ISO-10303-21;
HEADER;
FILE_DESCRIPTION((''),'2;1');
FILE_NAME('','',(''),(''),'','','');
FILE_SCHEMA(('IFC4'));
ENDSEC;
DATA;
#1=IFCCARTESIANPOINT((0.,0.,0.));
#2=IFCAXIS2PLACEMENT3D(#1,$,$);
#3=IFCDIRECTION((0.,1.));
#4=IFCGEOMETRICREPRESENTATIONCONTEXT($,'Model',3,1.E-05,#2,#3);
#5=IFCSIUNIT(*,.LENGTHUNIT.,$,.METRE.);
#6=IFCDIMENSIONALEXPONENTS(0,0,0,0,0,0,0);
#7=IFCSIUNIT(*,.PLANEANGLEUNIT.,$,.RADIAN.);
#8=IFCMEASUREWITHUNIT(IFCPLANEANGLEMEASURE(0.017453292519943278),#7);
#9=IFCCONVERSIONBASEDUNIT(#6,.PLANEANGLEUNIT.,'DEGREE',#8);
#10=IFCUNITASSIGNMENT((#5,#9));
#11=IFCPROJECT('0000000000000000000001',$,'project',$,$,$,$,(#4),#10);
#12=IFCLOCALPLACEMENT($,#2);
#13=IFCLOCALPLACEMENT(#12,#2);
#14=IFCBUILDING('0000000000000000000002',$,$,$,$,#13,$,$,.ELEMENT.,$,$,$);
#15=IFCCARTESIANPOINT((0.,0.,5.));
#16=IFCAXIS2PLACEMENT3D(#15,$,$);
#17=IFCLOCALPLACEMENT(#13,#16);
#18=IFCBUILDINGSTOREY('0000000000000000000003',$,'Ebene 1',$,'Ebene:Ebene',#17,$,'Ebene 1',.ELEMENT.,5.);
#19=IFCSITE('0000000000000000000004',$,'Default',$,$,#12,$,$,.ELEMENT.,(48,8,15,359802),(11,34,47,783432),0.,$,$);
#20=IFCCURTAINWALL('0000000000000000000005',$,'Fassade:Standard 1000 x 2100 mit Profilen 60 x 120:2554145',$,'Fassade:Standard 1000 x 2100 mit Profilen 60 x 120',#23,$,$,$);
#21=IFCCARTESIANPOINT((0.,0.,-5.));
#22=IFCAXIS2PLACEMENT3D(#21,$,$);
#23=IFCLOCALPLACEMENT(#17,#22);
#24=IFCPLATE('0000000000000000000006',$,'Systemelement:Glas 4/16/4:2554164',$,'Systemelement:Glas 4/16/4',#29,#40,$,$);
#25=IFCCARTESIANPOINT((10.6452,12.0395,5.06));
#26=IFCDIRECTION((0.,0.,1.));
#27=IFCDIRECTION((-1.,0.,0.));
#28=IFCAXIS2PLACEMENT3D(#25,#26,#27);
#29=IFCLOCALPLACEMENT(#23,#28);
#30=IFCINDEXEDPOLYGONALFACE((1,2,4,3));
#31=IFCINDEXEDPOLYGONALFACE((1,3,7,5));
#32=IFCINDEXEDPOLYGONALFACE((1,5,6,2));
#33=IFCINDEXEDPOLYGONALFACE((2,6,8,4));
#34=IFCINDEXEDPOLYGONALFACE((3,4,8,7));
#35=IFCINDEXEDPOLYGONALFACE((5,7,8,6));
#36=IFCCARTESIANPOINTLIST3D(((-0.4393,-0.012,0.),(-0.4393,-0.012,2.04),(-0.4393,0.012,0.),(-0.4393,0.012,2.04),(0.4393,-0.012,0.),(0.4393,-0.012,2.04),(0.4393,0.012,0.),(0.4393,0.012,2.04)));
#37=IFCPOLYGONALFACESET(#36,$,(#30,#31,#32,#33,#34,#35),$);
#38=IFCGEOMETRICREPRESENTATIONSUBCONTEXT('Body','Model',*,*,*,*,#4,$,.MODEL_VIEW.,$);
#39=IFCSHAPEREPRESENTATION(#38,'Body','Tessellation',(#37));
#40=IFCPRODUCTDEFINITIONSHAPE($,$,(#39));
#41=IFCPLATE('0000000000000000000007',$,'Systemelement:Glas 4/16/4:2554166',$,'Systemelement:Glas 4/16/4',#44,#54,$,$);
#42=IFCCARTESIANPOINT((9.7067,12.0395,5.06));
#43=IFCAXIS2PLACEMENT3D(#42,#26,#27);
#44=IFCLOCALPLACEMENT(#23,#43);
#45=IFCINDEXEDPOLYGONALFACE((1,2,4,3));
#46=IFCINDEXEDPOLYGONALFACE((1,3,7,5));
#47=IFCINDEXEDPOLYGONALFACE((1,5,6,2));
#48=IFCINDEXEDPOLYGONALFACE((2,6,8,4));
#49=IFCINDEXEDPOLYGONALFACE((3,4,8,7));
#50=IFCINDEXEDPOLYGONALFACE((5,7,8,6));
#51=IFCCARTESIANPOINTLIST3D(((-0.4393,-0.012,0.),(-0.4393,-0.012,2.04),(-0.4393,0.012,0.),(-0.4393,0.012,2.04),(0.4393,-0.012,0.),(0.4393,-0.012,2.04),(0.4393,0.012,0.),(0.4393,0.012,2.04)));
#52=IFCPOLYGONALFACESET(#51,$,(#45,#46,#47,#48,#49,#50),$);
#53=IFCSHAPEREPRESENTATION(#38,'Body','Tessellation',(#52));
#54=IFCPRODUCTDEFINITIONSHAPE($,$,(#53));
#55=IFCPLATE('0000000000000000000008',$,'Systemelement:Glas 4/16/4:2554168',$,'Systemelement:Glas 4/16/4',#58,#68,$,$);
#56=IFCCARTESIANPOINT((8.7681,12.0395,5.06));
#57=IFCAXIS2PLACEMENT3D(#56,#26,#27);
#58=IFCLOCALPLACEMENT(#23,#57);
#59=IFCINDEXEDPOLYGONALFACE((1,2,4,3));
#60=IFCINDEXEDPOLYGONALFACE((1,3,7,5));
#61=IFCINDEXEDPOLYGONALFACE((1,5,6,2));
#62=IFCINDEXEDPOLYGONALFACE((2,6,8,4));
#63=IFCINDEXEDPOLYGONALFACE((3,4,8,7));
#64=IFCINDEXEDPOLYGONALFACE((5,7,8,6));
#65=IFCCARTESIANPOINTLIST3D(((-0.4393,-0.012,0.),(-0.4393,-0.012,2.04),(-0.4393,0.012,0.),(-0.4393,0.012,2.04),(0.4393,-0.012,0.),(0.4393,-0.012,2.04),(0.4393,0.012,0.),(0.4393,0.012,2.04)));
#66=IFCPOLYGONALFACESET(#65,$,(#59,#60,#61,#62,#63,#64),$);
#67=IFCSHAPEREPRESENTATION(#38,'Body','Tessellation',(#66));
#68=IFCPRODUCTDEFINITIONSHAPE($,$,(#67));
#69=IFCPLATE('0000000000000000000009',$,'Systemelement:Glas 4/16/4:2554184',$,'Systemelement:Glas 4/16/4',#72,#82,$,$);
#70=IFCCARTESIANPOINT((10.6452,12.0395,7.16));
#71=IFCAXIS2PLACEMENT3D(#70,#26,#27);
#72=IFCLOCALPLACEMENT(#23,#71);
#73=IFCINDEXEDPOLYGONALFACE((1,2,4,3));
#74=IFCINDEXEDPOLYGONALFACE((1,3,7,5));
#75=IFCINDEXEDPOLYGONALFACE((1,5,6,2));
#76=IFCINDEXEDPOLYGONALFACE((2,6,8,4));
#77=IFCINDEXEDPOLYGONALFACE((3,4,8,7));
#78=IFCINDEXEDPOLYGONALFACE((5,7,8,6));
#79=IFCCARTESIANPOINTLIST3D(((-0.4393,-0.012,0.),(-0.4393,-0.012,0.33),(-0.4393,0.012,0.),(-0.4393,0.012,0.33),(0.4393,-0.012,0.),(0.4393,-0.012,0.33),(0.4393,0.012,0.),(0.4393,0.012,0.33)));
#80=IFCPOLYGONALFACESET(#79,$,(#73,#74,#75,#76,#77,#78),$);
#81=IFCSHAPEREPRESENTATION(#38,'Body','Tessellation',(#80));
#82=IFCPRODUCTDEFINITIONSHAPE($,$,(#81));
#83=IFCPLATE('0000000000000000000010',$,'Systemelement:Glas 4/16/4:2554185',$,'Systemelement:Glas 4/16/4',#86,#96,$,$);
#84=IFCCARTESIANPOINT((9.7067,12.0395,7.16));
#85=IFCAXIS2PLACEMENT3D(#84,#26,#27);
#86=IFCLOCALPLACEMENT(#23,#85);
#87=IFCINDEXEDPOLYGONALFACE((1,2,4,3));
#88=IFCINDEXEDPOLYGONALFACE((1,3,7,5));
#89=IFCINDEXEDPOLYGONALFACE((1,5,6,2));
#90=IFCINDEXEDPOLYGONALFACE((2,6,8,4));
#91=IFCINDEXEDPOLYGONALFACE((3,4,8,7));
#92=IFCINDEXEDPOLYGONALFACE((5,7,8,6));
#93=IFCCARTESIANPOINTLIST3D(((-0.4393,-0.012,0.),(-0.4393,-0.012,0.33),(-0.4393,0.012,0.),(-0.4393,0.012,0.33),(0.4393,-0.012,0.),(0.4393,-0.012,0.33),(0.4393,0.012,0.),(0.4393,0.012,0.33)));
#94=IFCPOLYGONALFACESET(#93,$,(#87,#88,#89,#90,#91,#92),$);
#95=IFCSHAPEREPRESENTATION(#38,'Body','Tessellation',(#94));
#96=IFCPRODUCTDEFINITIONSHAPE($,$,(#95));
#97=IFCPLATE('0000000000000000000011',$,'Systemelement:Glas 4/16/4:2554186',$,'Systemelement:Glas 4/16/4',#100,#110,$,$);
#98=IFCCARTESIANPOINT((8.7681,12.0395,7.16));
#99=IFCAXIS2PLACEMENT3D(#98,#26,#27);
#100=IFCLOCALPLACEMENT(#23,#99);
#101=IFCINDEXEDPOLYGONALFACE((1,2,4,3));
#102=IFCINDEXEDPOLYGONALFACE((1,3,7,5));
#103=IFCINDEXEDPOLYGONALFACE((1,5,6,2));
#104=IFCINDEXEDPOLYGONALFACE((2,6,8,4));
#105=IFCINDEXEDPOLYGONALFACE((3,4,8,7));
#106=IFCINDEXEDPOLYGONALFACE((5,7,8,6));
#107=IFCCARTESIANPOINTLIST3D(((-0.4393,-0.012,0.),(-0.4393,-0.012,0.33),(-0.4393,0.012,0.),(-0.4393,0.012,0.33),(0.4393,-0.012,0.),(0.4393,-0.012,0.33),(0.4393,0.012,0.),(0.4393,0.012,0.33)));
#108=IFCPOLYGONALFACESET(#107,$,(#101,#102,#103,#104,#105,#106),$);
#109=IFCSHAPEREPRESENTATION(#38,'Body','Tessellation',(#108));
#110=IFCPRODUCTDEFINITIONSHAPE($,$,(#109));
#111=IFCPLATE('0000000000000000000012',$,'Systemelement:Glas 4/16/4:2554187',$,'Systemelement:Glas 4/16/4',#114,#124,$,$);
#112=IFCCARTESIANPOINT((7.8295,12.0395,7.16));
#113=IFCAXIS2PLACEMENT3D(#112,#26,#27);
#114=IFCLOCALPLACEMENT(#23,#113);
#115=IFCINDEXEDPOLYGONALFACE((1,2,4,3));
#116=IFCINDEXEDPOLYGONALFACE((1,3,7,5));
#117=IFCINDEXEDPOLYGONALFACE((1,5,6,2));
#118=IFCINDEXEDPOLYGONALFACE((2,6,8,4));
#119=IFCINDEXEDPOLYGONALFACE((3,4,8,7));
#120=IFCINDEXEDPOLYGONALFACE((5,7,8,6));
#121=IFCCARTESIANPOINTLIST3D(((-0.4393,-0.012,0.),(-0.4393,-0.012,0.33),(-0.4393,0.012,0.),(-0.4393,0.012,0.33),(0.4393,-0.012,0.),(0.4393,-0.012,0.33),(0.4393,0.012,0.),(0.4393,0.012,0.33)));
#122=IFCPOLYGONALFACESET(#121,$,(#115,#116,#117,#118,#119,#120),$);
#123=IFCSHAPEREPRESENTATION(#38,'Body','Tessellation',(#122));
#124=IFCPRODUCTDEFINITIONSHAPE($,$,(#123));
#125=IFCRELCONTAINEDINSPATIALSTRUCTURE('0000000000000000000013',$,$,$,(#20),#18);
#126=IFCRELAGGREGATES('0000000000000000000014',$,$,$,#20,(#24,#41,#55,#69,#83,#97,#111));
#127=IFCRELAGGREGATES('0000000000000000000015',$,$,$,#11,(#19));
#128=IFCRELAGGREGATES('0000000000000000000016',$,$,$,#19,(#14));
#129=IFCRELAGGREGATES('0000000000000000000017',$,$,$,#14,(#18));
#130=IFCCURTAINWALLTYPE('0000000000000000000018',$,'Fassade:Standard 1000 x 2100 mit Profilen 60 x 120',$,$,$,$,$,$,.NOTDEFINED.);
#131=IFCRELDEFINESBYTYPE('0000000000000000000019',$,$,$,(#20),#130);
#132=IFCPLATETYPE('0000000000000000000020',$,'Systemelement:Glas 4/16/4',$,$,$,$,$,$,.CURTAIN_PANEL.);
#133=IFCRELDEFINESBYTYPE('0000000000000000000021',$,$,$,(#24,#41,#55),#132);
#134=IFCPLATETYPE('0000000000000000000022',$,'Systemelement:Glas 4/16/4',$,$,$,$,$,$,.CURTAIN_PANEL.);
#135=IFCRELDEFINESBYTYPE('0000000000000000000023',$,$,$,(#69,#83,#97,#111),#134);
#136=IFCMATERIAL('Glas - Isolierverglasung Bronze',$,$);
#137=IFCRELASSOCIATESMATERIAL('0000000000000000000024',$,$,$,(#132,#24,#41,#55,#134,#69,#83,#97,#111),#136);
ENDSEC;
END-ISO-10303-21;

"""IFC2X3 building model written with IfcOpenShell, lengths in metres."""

from ifc_helpers import new_model, entity, si_unit, converted_unit, direction, frame, origin, origin_2d_with_axis, place, context, subcontext, project, spatial, rectangle, extrude, source, transform, mapped, material, type_object, type_shapes, element, aggregate, save


model = new_model("IFC2X3")

# Units and contexts
model_context = context("Model", 3, precision=1e-05, world=origin(), true_north=direction((0.0, 1.0)))
body_context = subcontext(model_context, "Body", "Model", "MODEL_VIEW")
ifc_project = project(units=[si_unit("LENGTHUNIT", "METRE"), converted_unit("PLANEANGLEUNIT", "DEGREE", entity("IfcPlaneAngleMeasure", 0.017453292519943278), si_unit("PLANEANGLEUNIT", "RADIAN"), dimensions=[0, 0, 0, 0, 0, 0, 0])], contexts=[model_context])

# Site, building, storey
site_placement = place(None, origin())
site = spatial("IfcSite", under=ifc_project, at=site_placement, Name="Default", CompositionType="ELEMENT", RefLatitude=(48, 8, 15, 359802), RefLongitude=(11, 34, 47, 783432), RefElevation=0.0)
building_placement = place(site_placement, origin())
building = spatial("IfcBuilding", under=site, at=building_placement, CompositionType="ELEMENT")
storey_placement = place(building_placement, frame((0.0, 0.0, 5.0)))
storey = spatial("IfcBuildingStorey", under=building, at=storey_placement, Name="Ebene 1", ObjectType="Ebene:Ebene", LongName="Ebene 1", CompositionType="ELEMENT", Elevation=5.0)

# Curtain wall
curtain_wall_type = type_object("IfcCurtainWallType", Name="Fassade:Standard 1000 x 2100 mit Profilen 60 x 120", PredefinedType="NOTDEFINED")
curtain_wall_placement = place(storey_placement, frame((0.0, 0.0, -5.0)))
curtain_wall = element("IfcCurtainWall", 1, at=curtain_wall_placement, inside=storey, type_object=curtain_wall_type, Name="Fassade:Standard 1000 x 2100 mit Profilen 60 x 120:2554145", ObjectType="Fassade:Standard 1000 x 2100 mit Profilen 60 x 120")

# Plates
ifc_material_1 = material(Name="Glas - Isolierverglasung Bronze")
plate_type_1 = type_object("IfcPlateType", Name="Systemelement:Glas 4/16/4", PredefinedType="CURTAIN_PANEL", material=ifc_material_1)
shared_shape_1 = source(origin(), body_context, "Body", "SweptSolid", [
    extrude(rectangle(XDim=0.024, YDim=0.8786, at=origin_2d_with_axis()), frame((0.0, 0.0, 0.0), z_axis=(0.0, 0.0, 1.0), x_axis=(0.0, 1.0, 0.0)), (0.0, 0.0, 1.0), 2.04),
])
type_shapes(plate_type_1, [shared_shape_1])
plate_1_placement = place(curtain_wall_placement, frame((10.6452, 12.0395, 5.06), z_axis=(0.0, 0.0, 1.0), x_axis=(-1.0, 0.0, 0.0)))
plate_1 = element("IfcPlate", 2, at=plate_1_placement, type_object=plate_type_1, material=ifc_material_1, Name="Systemelement:Glas 4/16/4:2554164", ObjectType="Systemelement:Glas 4/16/4", context=body_context, shape_type="MappedRepresentation", body=[
    mapped(shared_shape_1, transform((0.0, 0.0, 0.0), scale=1.0)),
])
plate_2_placement = place(curtain_wall_placement, frame((9.7067, 12.0395, 5.06), z_axis=(0.0, 0.0, 1.0), x_axis=(-1.0, 0.0, 0.0)))
plate_2 = element("IfcPlate", 3, at=plate_2_placement, type_object=plate_type_1, material=ifc_material_1, Name="Systemelement:Glas 4/16/4:2554166", ObjectType="Systemelement:Glas 4/16/4", context=body_context, shape_type="MappedRepresentation", body=[
    mapped(shared_shape_1, transform((0.0, 0.0, 0.0), scale=1.0)),
])
plate_3_placement = place(curtain_wall_placement, frame((8.7681, 12.0395, 5.06), z_axis=(0.0, 0.0, 1.0), x_axis=(-1.0, 0.0, 0.0)))
plate_3 = element("IfcPlate", 4, at=plate_3_placement, type_object=plate_type_1, material=ifc_material_1, Name="Systemelement:Glas 4/16/4:2554168", ObjectType="Systemelement:Glas 4/16/4", context=body_context, shape_type="MappedRepresentation", body=[
    mapped(shared_shape_1, transform((0.0, 0.0, 0.0), scale=1.0)),
])
plate_type_2 = type_object("IfcPlateType", Name="Systemelement:Glas 4/16/4", PredefinedType="CURTAIN_PANEL", material=ifc_material_1)
shared_shape_2 = source(origin(), body_context, "Body", "SweptSolid", [
    extrude(rectangle(XDim=0.024, YDim=0.8786, at=origin_2d_with_axis()), frame((0.0, 0.0, 0.0), z_axis=(0.0, 0.0, 1.0), x_axis=(0.0, 1.0, 0.0)), (0.0, 0.0, 1.0), 0.33),
])
type_shapes(plate_type_2, [shared_shape_2])
plate_4_placement = place(curtain_wall_placement, frame((10.6452, 12.0395, 7.16), z_axis=(0.0, 0.0, 1.0), x_axis=(-1.0, 0.0, 0.0)))
plate_4 = element("IfcPlate", 5, at=plate_4_placement, type_object=plate_type_2, material=ifc_material_1, Name="Systemelement:Glas 4/16/4:2554184", ObjectType="Systemelement:Glas 4/16/4", context=body_context, shape_type="MappedRepresentation", body=[
    mapped(shared_shape_2, transform((0.0, 0.0, 0.0), scale=1.0)),
])
plate_5_placement = place(curtain_wall_placement, frame((9.7067, 12.0395, 7.16), z_axis=(0.0, 0.0, 1.0), x_axis=(-1.0, 0.0, 0.0)))
plate_5 = element("IfcPlate", 6, at=plate_5_placement, type_object=plate_type_2, material=ifc_material_1, Name="Systemelement:Glas 4/16/4:2554185", ObjectType="Systemelement:Glas 4/16/4", context=body_context, shape_type="MappedRepresentation", body=[
    mapped(shared_shape_2, transform((0.0, 0.0, 0.0), scale=1.0)),
])
plate_6_placement = place(curtain_wall_placement, frame((8.7681, 12.0395, 7.16), z_axis=(0.0, 0.0, 1.0), x_axis=(-1.0, 0.0, 0.0)))
plate_6 = element("IfcPlate", 7, at=plate_6_placement, type_object=plate_type_2, material=ifc_material_1, Name="Systemelement:Glas 4/16/4:2554186", ObjectType="Systemelement:Glas 4/16/4", context=body_context, shape_type="MappedRepresentation", body=[
    mapped(shared_shape_2, transform((0.0, 0.0, 0.0), scale=1.0)),
])
plate_7_placement = place(curtain_wall_placement, frame((7.8295, 12.0395, 7.16), z_axis=(0.0, 0.0, 1.0), x_axis=(-1.0, 0.0, 0.0)))
plate_7 = element("IfcPlate", 8, at=plate_7_placement, type_object=plate_type_2, material=ifc_material_1, Name="Systemelement:Glas 4/16/4:2554187", ObjectType="Systemelement:Glas 4/16/4", context=body_context, shape_type="MappedRepresentation", body=[
    mapped(shared_shape_2, transform((0.0, 0.0, 0.0), scale=1.0)),
])
aggregate(curtain_wall, [plate_1, plate_2, plate_3, plate_4, plate_5, plate_6, plate_7])

save(model, "model.ifc")
